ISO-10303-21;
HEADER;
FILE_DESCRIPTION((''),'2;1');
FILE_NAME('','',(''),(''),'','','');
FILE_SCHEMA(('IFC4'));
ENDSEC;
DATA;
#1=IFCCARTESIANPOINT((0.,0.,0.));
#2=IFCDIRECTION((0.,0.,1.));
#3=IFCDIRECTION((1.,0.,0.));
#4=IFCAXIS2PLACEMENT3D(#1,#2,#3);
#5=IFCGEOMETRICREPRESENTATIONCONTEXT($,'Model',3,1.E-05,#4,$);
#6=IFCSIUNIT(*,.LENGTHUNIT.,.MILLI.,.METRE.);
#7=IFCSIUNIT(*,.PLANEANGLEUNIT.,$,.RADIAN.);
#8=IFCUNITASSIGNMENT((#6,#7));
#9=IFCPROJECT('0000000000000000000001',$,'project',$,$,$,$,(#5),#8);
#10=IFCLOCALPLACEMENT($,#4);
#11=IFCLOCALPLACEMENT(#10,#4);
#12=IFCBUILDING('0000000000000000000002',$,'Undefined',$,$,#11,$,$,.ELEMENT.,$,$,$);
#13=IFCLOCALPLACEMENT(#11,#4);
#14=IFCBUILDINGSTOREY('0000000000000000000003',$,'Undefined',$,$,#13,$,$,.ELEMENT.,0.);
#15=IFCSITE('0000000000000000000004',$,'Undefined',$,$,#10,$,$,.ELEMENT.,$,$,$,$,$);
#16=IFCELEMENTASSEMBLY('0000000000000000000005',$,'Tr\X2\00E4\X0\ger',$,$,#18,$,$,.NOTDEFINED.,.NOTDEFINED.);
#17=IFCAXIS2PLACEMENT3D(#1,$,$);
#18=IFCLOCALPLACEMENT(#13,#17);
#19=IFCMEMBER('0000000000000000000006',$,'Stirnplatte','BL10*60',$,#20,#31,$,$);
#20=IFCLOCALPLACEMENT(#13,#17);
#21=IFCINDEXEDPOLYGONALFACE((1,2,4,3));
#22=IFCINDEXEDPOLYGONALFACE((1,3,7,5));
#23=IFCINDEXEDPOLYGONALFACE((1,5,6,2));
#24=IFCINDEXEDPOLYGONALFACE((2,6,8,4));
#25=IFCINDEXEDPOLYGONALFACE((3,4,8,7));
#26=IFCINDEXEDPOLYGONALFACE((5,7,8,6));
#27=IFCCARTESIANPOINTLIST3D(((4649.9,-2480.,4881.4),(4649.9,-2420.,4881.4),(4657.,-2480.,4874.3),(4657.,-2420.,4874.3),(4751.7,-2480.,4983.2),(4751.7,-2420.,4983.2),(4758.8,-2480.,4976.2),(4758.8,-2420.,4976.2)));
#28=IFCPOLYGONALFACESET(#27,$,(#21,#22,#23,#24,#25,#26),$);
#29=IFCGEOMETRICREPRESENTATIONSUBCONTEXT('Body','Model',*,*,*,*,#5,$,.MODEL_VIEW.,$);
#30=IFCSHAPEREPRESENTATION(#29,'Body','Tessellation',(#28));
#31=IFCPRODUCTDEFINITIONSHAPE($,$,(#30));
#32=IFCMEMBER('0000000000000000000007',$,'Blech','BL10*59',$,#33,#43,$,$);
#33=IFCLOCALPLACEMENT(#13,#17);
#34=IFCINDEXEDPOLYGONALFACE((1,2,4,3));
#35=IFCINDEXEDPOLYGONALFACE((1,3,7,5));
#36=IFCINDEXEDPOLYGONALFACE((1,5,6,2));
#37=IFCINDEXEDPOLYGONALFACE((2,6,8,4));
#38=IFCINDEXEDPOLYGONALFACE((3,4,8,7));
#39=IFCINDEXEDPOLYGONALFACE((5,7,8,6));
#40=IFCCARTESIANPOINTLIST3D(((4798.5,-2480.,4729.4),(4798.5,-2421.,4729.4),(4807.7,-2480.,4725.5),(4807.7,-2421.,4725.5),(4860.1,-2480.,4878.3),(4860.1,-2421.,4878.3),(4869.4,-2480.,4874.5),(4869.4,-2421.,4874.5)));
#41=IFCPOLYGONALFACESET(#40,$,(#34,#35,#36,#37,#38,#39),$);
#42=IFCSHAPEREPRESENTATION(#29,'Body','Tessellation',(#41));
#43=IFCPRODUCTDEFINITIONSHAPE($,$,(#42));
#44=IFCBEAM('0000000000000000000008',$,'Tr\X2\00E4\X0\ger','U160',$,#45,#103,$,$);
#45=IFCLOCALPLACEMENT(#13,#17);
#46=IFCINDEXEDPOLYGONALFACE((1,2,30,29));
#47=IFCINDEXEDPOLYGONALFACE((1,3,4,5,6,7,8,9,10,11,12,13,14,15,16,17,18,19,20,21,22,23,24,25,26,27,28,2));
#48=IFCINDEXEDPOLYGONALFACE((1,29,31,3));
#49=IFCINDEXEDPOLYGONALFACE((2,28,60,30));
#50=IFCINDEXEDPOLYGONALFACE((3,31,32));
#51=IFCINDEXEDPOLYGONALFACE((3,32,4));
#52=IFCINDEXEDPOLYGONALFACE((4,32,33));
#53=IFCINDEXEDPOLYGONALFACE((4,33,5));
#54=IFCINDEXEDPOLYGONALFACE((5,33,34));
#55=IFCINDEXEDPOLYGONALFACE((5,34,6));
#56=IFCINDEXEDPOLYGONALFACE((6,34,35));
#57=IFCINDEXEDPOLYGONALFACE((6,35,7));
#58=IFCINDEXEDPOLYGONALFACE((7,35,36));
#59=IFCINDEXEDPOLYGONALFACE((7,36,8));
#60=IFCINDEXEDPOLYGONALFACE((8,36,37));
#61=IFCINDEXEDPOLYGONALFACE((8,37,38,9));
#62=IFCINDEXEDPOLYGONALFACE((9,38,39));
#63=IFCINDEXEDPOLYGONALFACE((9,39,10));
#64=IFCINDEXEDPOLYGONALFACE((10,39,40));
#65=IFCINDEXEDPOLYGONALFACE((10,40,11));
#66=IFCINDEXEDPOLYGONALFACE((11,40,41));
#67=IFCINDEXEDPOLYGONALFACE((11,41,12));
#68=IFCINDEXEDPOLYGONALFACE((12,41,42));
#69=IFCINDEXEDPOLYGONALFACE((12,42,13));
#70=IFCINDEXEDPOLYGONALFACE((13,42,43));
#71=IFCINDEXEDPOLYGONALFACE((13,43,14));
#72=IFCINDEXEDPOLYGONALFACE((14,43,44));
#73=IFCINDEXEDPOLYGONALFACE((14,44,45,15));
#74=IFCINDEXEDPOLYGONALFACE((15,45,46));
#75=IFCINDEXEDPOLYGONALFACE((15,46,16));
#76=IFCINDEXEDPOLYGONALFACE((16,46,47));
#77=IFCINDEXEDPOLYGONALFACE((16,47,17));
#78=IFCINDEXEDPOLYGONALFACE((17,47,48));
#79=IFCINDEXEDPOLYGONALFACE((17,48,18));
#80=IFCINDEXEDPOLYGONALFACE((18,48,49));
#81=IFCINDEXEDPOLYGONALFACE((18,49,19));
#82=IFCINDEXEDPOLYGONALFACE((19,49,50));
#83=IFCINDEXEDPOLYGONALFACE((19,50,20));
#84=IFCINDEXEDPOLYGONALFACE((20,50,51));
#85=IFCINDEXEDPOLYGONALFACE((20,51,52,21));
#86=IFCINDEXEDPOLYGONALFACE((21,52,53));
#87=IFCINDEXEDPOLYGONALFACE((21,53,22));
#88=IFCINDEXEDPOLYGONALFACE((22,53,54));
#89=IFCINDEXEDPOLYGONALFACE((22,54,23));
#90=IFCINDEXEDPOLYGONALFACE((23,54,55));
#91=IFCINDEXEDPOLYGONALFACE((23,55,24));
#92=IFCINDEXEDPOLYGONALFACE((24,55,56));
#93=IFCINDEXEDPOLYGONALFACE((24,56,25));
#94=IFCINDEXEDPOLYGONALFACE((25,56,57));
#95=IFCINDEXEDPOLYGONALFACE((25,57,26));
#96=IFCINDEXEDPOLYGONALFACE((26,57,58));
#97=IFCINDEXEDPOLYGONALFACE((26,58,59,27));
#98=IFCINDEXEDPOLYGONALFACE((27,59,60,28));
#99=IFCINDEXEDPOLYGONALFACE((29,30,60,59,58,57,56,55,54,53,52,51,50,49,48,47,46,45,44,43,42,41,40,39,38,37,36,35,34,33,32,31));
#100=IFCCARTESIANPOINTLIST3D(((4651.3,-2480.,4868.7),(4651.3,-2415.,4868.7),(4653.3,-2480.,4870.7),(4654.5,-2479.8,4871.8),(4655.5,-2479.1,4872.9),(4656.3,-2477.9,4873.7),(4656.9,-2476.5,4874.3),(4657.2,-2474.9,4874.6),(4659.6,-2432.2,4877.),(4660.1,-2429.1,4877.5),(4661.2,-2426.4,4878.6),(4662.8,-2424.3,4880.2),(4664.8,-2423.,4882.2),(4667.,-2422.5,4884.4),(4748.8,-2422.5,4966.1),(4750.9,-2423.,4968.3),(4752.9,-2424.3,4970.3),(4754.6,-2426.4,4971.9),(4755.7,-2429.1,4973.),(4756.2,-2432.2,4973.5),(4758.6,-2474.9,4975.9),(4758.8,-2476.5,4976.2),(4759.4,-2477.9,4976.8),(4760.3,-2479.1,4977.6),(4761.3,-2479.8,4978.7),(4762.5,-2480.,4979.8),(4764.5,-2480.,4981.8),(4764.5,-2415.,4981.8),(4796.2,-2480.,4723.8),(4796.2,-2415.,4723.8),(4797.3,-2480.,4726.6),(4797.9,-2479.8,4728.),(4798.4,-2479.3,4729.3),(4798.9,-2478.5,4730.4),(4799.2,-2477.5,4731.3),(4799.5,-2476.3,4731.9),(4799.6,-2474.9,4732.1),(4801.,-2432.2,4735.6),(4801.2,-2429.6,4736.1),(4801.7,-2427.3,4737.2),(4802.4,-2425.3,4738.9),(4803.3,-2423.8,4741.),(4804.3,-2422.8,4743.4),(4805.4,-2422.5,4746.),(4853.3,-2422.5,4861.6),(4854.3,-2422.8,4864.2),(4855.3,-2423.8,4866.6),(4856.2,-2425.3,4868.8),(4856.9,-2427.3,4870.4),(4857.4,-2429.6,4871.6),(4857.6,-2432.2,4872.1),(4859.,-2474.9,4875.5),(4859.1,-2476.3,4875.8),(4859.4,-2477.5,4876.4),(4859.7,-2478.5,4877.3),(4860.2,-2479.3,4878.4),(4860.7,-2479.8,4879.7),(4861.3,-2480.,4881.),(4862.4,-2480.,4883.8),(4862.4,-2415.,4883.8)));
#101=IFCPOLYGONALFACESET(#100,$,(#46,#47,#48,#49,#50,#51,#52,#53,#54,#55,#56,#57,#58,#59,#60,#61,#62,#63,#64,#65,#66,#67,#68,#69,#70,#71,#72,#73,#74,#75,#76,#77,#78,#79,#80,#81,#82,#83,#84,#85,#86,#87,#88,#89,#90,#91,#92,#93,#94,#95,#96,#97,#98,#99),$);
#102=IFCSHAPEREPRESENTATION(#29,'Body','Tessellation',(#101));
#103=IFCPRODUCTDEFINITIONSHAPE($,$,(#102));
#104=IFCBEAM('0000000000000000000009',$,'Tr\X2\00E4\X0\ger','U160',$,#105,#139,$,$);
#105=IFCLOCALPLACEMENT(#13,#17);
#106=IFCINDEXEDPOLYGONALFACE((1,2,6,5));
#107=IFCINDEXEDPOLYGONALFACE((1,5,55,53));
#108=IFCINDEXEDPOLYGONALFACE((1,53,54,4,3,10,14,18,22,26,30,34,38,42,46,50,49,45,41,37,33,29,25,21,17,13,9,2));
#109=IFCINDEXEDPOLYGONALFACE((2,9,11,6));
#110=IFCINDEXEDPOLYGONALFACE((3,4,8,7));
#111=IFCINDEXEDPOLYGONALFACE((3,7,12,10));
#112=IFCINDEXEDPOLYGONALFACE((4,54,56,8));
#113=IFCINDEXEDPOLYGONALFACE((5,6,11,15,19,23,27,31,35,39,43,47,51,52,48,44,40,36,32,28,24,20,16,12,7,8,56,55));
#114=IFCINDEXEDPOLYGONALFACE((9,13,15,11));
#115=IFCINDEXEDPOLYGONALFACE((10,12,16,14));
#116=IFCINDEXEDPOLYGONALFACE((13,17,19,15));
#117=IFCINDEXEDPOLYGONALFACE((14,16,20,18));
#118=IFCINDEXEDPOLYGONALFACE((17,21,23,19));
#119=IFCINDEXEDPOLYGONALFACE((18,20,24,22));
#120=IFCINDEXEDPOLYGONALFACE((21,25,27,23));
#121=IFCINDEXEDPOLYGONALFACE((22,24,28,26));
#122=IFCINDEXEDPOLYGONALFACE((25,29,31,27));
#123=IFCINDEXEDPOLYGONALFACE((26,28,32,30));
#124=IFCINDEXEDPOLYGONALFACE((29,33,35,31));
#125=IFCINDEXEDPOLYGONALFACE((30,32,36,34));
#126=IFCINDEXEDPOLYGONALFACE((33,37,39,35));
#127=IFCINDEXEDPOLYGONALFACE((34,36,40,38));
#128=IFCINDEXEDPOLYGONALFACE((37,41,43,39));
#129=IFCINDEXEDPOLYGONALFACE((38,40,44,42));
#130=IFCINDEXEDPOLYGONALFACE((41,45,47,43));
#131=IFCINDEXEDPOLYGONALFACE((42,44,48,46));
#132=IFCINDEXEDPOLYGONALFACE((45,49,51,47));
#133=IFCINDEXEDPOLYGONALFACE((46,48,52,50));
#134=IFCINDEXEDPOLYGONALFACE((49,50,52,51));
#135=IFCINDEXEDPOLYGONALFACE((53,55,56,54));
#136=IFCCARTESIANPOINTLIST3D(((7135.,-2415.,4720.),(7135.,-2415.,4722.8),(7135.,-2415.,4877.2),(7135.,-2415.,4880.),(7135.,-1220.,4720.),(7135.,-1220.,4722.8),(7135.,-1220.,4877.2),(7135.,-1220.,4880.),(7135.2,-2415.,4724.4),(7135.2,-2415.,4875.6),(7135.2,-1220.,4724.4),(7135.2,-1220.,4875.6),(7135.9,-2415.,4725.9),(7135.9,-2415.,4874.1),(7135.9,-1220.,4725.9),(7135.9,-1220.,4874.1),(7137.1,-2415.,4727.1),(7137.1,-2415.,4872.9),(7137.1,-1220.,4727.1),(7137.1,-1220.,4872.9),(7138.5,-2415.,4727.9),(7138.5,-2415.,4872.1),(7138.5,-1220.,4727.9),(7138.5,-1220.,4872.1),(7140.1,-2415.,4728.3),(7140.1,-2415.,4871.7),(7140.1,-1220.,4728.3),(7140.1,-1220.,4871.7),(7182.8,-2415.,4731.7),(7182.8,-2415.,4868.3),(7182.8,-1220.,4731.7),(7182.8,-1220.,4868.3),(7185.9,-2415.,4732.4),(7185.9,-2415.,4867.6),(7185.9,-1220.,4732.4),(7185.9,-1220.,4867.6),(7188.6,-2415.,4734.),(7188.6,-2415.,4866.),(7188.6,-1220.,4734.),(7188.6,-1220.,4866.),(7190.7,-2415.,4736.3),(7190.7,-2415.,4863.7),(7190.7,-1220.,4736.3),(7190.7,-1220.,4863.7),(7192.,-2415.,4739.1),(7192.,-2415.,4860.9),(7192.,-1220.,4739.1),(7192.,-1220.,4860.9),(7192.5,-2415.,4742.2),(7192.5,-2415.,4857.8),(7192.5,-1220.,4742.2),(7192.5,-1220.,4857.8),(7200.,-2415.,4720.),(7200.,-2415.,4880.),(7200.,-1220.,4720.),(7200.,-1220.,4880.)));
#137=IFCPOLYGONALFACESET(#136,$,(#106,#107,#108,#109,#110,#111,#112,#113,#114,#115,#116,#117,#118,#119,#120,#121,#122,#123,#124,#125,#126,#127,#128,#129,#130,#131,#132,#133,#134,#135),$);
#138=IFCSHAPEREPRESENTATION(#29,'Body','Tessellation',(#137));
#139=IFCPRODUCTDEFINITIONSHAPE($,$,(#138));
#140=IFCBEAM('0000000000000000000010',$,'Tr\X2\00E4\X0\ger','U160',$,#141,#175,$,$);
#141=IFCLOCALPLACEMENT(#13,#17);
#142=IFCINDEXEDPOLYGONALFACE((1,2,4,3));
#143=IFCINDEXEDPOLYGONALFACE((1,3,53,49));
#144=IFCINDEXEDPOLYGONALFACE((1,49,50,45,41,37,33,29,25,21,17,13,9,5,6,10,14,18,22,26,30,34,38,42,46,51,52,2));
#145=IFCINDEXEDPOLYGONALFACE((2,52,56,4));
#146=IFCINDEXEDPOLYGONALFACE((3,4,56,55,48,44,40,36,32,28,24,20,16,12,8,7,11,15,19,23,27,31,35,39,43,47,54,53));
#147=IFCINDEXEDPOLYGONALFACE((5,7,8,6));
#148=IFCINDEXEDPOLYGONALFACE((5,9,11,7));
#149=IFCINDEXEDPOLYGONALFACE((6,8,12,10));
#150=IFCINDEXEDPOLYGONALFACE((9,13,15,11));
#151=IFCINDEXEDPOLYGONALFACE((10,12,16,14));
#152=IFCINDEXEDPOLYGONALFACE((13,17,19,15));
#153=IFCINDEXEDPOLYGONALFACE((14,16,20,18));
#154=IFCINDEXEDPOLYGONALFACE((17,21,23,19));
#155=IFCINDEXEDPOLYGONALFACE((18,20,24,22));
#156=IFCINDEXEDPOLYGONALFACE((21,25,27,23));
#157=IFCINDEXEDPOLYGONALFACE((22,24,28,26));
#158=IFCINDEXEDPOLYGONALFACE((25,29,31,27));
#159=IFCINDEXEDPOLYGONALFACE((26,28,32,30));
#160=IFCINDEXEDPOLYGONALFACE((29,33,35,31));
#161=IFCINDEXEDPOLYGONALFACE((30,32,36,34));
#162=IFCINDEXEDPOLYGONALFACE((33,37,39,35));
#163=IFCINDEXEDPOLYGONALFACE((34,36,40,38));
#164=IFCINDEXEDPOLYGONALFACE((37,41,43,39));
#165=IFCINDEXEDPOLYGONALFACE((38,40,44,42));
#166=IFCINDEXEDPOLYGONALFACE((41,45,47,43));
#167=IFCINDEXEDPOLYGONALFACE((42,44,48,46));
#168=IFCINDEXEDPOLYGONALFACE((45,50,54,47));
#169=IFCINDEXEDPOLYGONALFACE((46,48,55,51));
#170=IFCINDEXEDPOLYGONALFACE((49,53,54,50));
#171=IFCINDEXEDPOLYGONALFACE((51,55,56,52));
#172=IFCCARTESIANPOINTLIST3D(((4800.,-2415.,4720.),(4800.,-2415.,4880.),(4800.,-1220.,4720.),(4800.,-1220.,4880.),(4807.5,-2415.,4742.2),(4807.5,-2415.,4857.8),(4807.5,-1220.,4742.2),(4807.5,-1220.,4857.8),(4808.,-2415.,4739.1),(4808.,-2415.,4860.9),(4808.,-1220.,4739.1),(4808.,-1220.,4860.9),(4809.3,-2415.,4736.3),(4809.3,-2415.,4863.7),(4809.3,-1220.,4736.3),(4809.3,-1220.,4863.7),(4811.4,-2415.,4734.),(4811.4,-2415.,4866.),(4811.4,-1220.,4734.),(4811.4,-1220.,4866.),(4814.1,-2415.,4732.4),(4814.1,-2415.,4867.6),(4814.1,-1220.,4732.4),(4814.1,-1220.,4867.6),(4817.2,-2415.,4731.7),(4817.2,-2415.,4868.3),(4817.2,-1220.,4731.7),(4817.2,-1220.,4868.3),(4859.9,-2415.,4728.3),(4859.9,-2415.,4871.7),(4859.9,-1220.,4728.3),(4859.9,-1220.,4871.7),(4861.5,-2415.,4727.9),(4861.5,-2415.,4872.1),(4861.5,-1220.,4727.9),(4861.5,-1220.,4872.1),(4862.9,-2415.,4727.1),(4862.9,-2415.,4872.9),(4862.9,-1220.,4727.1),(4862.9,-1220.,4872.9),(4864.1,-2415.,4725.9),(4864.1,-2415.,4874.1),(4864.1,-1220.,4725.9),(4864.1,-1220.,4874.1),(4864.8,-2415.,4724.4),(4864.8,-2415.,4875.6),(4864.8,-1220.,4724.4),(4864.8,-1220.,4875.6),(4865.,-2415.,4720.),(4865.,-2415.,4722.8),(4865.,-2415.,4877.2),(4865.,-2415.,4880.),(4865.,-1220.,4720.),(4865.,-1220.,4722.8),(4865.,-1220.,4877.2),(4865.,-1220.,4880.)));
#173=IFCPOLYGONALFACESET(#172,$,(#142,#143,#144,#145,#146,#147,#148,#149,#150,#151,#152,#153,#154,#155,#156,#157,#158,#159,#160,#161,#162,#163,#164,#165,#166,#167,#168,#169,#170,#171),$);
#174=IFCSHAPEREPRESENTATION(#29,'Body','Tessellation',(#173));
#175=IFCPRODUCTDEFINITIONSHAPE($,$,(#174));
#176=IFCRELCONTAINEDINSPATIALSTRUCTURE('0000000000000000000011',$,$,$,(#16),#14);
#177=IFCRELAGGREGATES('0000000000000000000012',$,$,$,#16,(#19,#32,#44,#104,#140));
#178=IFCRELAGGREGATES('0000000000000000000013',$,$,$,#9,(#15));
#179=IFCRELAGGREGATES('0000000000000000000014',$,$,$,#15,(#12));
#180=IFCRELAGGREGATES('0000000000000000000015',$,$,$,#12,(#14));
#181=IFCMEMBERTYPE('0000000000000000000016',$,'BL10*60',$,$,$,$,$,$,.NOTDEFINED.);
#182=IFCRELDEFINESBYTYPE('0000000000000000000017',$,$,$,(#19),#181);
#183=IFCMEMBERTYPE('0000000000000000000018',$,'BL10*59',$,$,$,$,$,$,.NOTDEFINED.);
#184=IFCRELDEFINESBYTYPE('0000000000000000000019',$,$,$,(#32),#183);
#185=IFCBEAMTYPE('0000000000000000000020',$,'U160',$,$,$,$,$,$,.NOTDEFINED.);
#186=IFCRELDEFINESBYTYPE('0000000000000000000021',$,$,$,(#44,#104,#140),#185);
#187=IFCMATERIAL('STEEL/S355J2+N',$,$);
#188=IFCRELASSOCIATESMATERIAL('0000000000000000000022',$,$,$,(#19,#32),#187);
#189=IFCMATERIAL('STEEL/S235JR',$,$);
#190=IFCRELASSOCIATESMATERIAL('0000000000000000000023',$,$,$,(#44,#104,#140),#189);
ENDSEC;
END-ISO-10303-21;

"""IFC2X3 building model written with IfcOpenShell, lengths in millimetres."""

from ifc_helpers import new_model, si_unit, frame, origin_with_axes, origin_2d_with_axis, place, context, subcontext, project, spatial, rectangle, u_section, extrude, clip, halfspace, material, type_object, element, aggregate, save


model = new_model("IFC2X3")

# Units and contexts
model_context = context("Model", 3, precision=1e-05, world=origin_with_axes())
body_context = subcontext(model_context, "Body", "Model", "MODEL_VIEW")
ifc_project = project(units=[si_unit("LENGTHUNIT", "METRE", prefix="MILLI"), si_unit("PLANEANGLEUNIT", "RADIAN")], contexts=[model_context])

# Site, building, storey
site_placement = place(None, origin_with_axes())
site = spatial("IfcSite", under=ifc_project, at=site_placement, Name="Undefined", CompositionType="ELEMENT")
building_placement = place(site_placement, origin_with_axes())
building = spatial("IfcBuilding", under=site, at=building_placement, Name="Undefined", CompositionType="ELEMENT")
storey_placement = place(building_placement, origin_with_axes())
storey = spatial("IfcBuildingStorey", under=building, at=storey_placement, Name="Undefined", CompositionType="ELEMENT", Elevation=0.0)

# Element assembly, members, beams
assembly_placement = place(storey_placement, origin_with_axes())
assembly = element("IfcElementAssembly", 1, at=assembly_placement, inside=storey, Name="Träger", AssemblyPlace="NOTDEFINED", PredefinedType="NOTDEFINED")
ifc_material_1 = material(Name="STEEL/S355J2+N")
member_type_1 = type_object("IfcMemberType", Name="BL10*60", PredefinedType="NOTDEFINED")
member_1_placement = place(assembly_placement, frame((4653.4, -2450.0, 4877.9), z_axis=(0.0, -1.0, 0.0), x_axis=(0.707107, 0.0, 0.707107)))
member_1 = element("IfcMember", 2, at=member_1_placement, type_object=member_type_1, material=ifc_material_1, Name="Stirnplatte", Description="BL10*60", context=body_context, shape_type="SweptSolid", body=[
    extrude(rectangle(XDim=10.0, YDim=60.0, at=origin_2d_with_axis()), frame((144.0, 0.0, 0.0), z_axis=(-1.0, 0.0, 0.0), x_axis=(0.0, -1.0, 0.0)), (0.0, 0.0, 1.0), 144.0),
])
member_type_2 = type_object("IfcMemberType", Name="BL10*59", PredefinedType="NOTDEFINED")
member_2_placement = place(assembly_placement, frame((4864.8, -2450.5, 4876.4), z_axis=(0.0, 1.0, 0.0), x_axis=(-0.382683, 0.0, -0.92388)))
member_2 = element("IfcMember", 3, at=member_2_placement, type_object=member_type_2, material=ifc_material_1, Name="Blech", Description="BL10*59", context=body_context, shape_type="SweptSolid", body=[
    extrude(rectangle(XDim=10.0, YDim=59.0, at=origin_2d_with_axis()), frame((161.2, 0.0, 0.0), z_axis=(-1.0, 0.0, 0.0), x_axis=(0.0, -1.0, 0.0)), (0.0, 0.0, 1.0), 161.2),
])
ifc_material_2 = material(Name="STEEL/S235JR")
beam_type_1 = type_object("IfcBeamType", Name="U160", PredefinedType="NOTDEFINED")
beam_1_placement = place(assembly_placement, frame((4700.8, -2447.5, 4932.3), z_axis=(0.707107, 0.0, 0.707107), x_axis=(0.707107, 0.0, -0.707107)))
beam_1 = element("IfcBeam", 4, at=beam_1_placement, type_object=beam_type_1, material=ifc_material_2, Name="Träger", Description="U160", context=body_context, shape_type="Clipping", body=[
    clip(clip(extrude(u_section(Depth=160.0, FlangeWidth=65.0, WebThickness=7.5, FlangeThickness=10.5, FilletRadius=10.5, EdgeRadius=5.5, FlangeSlope=0.07983, at=origin_2d_with_axis()), frame((343.3, 0.0, 0.0), z_axis=(-1.0, 0.0, 0.0), x_axis=(0.0, -1.0, 0.0)), (0.0, 0.0, 1.0), 494.9), halfspace(frame((149.4, 0.0, 78.1), z_axis=(0.92388, 0.0, 0.382683), x_axis=(0.0, 1.0, 0.0)), False)), halfspace(frame((10.0, 0.0, -80.0), z_axis=(1.0, 0.0, 0.0), x_axis=(0.0, -1.0, 0.0)), True)),
])
beam_2_placement = place(assembly_placement, frame((7167.5, -1220.0, 4800.0), z_axis=(0.0, 0.0, 1.0), x_axis=(0.0, -1.0, 0.0)))
beam_2 = element("IfcBeam", 5, at=beam_2_placement, type_object=beam_type_1, material=ifc_material_2, Name="Träger", Description="U160", context=body_context, shape_type="SweptSolid", body=[
    extrude(u_section(Depth=160.0, FlangeWidth=65.0, WebThickness=7.5, FlangeThickness=10.5, FilletRadius=10.5, EdgeRadius=5.5, FlangeSlope=0.07983, at=origin_2d_with_axis()), frame((1195.0, 0.0, 0.0), z_axis=(-1.0, 0.0, 0.0), x_axis=(0.0, -1.0, 0.0)), (0.0, 0.0, 1.0), 1195.0),
])
beam_3_placement = place(assembly_placement, frame((4832.5, -1220.0, 4800.0), z_axis=(0.0, 0.0, -1.0), x_axis=(0.0, -1.0, 0.0)))
beam_3 = element("IfcBeam", 6, at=beam_3_placement, type_object=beam_type_1, material=ifc_material_2, Name="Träger", Description="U160", context=body_context, shape_type="SweptSolid", body=[
    extrude(u_section(Depth=160.0, FlangeWidth=65.0, WebThickness=7.5, FlangeThickness=10.5, FilletRadius=10.5, EdgeRadius=5.5, FlangeSlope=0.07983, at=origin_2d_with_axis()), frame((1195.0, 0.0, 0.0), z_axis=(-1.0, 0.0, 0.0), x_axis=(0.0, -1.0, 0.0)), (0.0, 0.0, 1.0), 1195.0),
])
aggregate(assembly, [member_1, member_2, beam_1, beam_2, beam_3])

save(model, "model.ifc")
